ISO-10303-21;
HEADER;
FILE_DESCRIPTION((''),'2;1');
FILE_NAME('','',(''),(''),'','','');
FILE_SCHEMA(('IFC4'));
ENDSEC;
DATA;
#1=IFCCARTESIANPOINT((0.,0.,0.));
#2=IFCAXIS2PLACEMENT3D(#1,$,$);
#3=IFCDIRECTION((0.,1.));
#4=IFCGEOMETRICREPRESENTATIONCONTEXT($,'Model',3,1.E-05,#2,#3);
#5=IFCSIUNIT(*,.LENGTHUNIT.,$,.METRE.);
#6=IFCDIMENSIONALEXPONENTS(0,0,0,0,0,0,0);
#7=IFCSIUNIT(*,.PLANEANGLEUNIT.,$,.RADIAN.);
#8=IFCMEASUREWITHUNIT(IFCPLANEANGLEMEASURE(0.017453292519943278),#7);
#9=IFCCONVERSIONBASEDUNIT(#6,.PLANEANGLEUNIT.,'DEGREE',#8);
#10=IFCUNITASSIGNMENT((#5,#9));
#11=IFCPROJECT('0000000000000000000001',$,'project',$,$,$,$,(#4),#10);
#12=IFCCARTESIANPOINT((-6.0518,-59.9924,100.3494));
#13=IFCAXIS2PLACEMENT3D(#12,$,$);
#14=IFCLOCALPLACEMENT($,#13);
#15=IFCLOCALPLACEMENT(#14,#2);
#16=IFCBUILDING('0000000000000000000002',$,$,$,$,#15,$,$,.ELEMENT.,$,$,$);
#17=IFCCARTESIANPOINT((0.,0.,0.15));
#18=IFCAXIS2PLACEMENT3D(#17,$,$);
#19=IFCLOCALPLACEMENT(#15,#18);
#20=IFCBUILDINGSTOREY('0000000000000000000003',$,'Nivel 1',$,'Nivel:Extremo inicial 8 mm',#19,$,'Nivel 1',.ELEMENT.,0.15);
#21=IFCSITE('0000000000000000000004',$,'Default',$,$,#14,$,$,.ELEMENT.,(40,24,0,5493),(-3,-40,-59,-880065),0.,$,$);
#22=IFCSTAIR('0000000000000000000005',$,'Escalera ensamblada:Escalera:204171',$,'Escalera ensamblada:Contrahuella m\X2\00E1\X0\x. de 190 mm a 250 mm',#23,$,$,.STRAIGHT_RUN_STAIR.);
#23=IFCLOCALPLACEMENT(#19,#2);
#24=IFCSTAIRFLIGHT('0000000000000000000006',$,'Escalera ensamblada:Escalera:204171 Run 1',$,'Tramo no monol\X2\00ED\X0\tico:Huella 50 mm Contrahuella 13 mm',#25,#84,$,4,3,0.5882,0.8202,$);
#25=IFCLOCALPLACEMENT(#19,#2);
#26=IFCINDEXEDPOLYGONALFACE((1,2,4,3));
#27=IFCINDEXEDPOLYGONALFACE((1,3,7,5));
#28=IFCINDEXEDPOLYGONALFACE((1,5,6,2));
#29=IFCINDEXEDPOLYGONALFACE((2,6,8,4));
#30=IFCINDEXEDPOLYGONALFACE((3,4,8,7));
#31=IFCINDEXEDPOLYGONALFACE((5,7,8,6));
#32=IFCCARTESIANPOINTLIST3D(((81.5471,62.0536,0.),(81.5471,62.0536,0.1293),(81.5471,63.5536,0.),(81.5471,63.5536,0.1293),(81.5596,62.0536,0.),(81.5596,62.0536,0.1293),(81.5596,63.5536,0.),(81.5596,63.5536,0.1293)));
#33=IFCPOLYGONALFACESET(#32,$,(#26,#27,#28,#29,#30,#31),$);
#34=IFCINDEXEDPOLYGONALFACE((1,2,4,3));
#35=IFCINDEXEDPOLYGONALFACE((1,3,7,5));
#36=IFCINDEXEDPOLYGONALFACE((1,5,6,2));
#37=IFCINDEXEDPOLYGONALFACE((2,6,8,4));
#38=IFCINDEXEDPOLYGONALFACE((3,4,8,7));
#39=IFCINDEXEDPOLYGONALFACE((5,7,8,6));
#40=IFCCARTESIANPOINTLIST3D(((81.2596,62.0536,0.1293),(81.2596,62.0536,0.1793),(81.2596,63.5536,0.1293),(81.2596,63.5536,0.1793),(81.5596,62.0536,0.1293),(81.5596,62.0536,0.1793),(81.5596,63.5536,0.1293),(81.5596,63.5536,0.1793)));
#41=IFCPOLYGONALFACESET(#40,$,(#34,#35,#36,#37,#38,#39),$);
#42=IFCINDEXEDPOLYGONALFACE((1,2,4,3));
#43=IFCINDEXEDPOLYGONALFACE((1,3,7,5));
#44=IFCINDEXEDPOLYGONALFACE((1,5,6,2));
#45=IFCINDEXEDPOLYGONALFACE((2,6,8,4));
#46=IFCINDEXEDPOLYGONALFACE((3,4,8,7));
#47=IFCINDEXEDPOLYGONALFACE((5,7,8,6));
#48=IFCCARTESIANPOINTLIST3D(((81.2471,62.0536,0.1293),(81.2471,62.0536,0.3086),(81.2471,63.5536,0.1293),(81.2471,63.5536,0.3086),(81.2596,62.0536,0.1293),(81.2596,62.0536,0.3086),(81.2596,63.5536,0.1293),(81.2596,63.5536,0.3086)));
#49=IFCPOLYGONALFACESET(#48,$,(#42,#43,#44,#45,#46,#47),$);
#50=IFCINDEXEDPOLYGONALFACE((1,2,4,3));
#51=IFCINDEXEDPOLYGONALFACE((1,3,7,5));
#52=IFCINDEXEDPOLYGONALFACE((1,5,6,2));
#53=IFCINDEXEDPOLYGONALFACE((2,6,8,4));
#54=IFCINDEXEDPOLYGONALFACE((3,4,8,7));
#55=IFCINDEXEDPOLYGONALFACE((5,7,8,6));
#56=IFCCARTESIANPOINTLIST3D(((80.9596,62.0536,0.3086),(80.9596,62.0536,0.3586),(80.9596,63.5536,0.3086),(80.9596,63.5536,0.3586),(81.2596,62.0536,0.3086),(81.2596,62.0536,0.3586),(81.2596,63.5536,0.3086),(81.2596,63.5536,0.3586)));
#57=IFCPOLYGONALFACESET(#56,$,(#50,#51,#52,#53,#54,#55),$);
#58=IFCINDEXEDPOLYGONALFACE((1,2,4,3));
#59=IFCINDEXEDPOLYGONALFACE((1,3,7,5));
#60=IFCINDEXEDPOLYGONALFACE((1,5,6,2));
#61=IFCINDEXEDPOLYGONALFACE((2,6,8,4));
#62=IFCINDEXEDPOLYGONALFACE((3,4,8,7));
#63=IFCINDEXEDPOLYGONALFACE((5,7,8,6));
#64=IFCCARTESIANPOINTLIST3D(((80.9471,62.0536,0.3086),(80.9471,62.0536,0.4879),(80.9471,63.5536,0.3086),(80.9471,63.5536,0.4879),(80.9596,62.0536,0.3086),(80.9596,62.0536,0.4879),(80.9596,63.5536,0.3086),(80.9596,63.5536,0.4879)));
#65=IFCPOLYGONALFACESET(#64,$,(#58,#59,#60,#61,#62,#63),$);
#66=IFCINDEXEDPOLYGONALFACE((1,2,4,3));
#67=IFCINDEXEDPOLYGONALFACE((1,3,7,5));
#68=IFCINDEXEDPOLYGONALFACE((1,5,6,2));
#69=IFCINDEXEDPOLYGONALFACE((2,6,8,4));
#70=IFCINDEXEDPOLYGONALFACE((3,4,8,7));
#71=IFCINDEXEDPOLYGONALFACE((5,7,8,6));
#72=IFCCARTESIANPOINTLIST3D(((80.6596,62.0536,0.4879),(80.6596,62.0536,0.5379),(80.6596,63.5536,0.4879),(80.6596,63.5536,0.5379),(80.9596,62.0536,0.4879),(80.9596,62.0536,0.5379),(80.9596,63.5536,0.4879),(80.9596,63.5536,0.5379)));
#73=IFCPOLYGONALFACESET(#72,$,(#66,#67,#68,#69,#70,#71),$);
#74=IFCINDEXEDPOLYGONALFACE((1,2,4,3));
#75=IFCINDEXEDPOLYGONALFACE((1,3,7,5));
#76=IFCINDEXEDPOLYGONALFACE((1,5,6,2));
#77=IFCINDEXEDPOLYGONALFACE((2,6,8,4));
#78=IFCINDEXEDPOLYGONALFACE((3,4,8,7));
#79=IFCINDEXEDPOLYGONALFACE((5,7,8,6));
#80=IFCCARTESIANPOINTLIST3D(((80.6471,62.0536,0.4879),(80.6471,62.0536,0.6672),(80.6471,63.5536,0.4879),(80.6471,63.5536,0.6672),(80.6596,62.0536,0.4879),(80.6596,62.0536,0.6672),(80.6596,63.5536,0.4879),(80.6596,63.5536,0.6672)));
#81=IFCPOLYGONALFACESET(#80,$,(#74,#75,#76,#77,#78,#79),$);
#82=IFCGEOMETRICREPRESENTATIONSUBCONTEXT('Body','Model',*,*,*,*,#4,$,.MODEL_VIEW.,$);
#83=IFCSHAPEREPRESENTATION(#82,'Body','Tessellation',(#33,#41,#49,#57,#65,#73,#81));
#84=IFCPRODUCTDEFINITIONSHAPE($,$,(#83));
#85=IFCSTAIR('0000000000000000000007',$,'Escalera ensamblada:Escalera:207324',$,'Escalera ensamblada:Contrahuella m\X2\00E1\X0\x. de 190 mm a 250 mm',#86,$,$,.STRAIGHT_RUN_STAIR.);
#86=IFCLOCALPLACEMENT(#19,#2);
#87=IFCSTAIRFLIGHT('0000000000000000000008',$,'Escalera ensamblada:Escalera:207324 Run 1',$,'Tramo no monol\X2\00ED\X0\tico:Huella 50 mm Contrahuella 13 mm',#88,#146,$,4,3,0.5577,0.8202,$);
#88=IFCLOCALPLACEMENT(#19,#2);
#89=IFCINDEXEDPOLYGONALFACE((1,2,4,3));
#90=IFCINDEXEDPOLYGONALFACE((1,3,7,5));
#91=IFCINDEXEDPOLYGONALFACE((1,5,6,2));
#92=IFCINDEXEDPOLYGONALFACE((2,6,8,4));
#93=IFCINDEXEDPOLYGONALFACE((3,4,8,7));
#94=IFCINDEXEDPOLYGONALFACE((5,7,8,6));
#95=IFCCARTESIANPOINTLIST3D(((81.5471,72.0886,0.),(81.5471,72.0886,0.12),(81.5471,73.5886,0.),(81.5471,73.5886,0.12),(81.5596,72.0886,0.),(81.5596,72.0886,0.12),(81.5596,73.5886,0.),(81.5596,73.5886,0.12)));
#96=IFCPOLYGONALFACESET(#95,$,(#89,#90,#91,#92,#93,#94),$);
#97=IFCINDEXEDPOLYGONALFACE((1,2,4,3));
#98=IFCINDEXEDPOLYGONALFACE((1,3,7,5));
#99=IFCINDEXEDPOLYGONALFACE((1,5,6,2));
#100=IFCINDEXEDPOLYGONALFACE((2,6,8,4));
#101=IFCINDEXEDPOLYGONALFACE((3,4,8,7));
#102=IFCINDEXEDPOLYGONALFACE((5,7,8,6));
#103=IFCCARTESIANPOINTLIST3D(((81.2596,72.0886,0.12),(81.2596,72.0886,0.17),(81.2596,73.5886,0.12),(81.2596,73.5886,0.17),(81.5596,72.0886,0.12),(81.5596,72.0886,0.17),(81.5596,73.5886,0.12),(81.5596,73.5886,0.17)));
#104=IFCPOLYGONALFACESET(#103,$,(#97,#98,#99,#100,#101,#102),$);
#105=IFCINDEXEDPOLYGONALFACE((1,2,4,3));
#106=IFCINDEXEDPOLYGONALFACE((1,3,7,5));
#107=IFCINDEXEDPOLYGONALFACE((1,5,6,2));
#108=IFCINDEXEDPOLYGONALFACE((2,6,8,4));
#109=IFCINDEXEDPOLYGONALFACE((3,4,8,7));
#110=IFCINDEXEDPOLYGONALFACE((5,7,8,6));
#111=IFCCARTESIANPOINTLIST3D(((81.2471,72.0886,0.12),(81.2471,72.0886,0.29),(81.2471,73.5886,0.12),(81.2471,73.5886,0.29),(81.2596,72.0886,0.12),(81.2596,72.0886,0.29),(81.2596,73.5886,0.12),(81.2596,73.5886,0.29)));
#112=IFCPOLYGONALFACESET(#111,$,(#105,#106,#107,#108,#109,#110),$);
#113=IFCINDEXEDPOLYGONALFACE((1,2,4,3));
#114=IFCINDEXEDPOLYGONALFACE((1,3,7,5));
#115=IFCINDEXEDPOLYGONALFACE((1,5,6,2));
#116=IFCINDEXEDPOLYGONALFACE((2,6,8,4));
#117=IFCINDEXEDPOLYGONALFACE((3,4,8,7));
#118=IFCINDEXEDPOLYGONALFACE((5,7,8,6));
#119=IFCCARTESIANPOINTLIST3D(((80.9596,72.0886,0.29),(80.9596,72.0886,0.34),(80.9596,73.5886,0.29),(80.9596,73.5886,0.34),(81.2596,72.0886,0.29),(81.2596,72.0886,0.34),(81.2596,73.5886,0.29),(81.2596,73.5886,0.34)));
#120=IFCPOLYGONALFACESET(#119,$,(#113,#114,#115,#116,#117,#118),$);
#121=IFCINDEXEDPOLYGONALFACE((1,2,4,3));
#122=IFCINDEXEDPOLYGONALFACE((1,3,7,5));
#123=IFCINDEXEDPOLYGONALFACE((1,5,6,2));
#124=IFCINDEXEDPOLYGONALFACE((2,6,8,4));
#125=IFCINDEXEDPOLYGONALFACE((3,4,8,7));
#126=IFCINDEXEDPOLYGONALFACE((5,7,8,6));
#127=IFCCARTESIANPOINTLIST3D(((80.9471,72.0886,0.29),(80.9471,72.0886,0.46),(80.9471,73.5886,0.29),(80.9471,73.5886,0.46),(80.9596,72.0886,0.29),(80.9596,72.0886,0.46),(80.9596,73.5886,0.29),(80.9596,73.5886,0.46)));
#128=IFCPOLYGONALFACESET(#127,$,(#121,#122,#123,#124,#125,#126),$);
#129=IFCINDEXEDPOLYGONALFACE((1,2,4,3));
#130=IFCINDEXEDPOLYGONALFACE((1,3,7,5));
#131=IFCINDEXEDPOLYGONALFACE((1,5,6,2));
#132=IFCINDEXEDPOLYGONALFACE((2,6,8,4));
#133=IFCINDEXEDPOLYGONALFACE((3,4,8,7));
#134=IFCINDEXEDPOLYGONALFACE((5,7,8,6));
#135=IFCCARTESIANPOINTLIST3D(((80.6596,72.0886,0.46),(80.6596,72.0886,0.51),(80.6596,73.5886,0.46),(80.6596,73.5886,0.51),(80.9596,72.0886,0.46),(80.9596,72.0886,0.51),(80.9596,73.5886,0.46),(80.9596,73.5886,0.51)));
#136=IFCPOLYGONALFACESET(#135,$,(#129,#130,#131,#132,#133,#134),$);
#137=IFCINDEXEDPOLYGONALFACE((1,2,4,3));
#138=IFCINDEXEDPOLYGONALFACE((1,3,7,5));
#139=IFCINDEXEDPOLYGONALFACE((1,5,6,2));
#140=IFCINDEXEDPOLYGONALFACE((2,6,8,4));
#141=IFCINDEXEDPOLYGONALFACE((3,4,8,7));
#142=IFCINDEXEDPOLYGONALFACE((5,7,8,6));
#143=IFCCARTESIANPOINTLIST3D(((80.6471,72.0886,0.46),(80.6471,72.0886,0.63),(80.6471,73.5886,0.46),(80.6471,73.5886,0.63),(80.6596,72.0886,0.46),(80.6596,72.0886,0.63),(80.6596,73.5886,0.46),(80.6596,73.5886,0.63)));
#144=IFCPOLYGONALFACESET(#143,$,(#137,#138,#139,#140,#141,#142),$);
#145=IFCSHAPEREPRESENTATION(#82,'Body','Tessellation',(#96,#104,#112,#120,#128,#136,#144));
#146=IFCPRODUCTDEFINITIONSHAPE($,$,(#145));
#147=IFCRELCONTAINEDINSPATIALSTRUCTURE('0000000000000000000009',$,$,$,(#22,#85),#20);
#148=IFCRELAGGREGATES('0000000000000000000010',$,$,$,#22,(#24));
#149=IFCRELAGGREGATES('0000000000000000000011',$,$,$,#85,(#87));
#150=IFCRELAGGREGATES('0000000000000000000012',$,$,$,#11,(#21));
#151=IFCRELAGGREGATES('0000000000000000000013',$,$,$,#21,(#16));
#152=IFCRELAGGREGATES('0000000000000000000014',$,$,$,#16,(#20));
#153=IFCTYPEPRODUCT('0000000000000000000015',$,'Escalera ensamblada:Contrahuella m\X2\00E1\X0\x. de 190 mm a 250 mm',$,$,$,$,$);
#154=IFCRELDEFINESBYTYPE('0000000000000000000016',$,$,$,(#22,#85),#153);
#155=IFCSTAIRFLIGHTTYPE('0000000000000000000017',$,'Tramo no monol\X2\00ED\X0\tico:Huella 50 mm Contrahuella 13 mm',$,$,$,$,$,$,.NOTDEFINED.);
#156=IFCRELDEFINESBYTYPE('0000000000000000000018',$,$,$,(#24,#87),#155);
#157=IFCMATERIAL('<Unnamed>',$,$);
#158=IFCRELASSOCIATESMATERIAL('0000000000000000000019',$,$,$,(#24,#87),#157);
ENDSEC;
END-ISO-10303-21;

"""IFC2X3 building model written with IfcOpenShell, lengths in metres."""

from ifc_helpers import new_model, entity, si_unit, converted_unit, direction, frame, frame_2d, origin, origin_2d_with_axis, place, context, subcontext, project, spatial, rectangle, extrude, material, type_object, element, aggregate, save


model = new_model("IFC2X3")

# Units and contexts
model_context = context("Model", 3, precision=1e-05, world=origin(), true_north=direction((0.0, 1.0)))
body_context = subcontext(model_context, "Body", "Model", "MODEL_VIEW")
ifc_project = project(units=[si_unit("LENGTHUNIT", "METRE"), converted_unit("PLANEANGLEUNIT", "DEGREE", entity("IfcPlaneAngleMeasure", 0.017453292519943278), si_unit("PLANEANGLEUNIT", "RADIAN"), dimensions=[0, 0, 0, 0, 0, 0, 0])], contexts=[model_context])

# Site, building, storey
site_placement = place(None, frame((-6.0518, -59.9924, 100.3494)))
site = spatial("IfcSite", under=ifc_project, at=site_placement, Name="Default", CompositionType="ELEMENT", RefLatitude=(40, 24, 0, 5493), RefLongitude=(-3, -40, -59, -880065), RefElevation=0.0)
building_placement = place(site_placement, origin())
building = spatial("IfcBuilding", under=site, at=building_placement, CompositionType="ELEMENT")
storey_placement = place(building_placement, frame((0.0, 0.0, 0.15)))
storey = spatial("IfcBuildingStorey", under=building, at=storey_placement, Name="Nivel 1", ObjectType="Nivel:Extremo inicial 8 mm", LongName="Nivel 1", CompositionType="ELEMENT", Elevation=0.15)

# Stairs, stair flights
type_product = type_object("IfcTypeProduct", Name="Escalera ensamblada:Contrahuella máx. de 190 mm a 250 mm")
stair_1_placement = place(storey_placement, origin())
stair_1 = element("IfcStair", 1, at=stair_1_placement, inside=storey, type_object=type_product, Name="Escalera ensamblada:Escalera:204171", ObjectType="Escalera ensamblada:Contrahuella máx. de 190 mm a 250 mm", ShapeType="STRAIGHT_RUN_STAIR")
ifc_material_1 = material(Name="<Unnamed>")
stair_flight_type = type_object("IfcStairFlightType", Name="Tramo no monolítico:Huella 50 mm Contrahuella 13 mm", PredefinedType="NOTDEFINED")
stair_flight_1_placement = place(stair_1_placement, origin())
stair_flight_1 = element("IfcStairFlight", 2, at=stair_flight_1_placement, type_object=stair_flight_type, material=ifc_material_1, Name="Escalera ensamblada:Escalera:204171 Run 1", ObjectType="Tramo no monolítico:Huella 50 mm Contrahuella 13 mm", NumberOfRiser=4, NumberOfTreads=3, RiserHeight=0.5882, TreadLength=0.8202, context=body_context, shape_type="SweptSolid", body=[
    extrude(rectangle(XDim=1.5, YDim=0.0125, at=origin_2d_with_axis()), frame((81.5534, 62.8036, 0.0), z_axis=(0.0, 0.0, 1.0), x_axis=(0.0, -1.0, 0.0)), (0.0, 0.0, 1.0), 0.1293),
    extrude(rectangle(XDim=0.3, YDim=1.5, at=frame_2d((0.0, 0.0), x_axis=(1.0, 0.0))), frame((81.4096, 62.8036, 0.1293)), (0.0, 0.0, 1.0), 0.05),
    extrude(rectangle(XDim=1.5, YDim=0.0125, at=origin_2d_with_axis()), frame((81.2534, 62.8036, 0.1293), z_axis=(0.0, 0.0, 1.0), x_axis=(0.0, -1.0, 0.0)), (0.0, 0.0, 1.0), 0.1793),
    extrude(rectangle(XDim=0.3, YDim=1.5, at=frame_2d((0.0, 0.0), x_axis=(1.0, 0.0))), frame((81.1096, 62.8036, 0.3086)), (0.0, 0.0, 1.0), 0.05),
    extrude(rectangle(XDim=1.5, YDim=0.0125, at=origin_2d_with_axis()), frame((80.9534, 62.8036, 0.3086), z_axis=(0.0, 0.0, 1.0), x_axis=(0.0, -1.0, 0.0)), (0.0, 0.0, 1.0), 0.1793),
    extrude(rectangle(XDim=0.3, YDim=1.5, at=frame_2d((0.0, 0.0), x_axis=(1.0, 0.0))), frame((80.8096, 62.8036, 0.4879)), (0.0, 0.0, 1.0), 0.05),
    extrude(rectangle(XDim=1.5, YDim=0.0125, at=origin_2d_with_axis()), frame((80.6534, 62.8036, 0.4879), z_axis=(0.0, 0.0, 1.0), x_axis=(0.0, -1.0, 0.0)), (0.0, 0.0, 1.0), 0.1793),
])
aggregate(stair_1, [stair_flight_1])
stair_2_placement = place(storey_placement, origin())
stair_2 = element("IfcStair", 3, at=stair_2_placement, inside=storey, type_object=type_product, Name="Escalera ensamblada:Escalera:207324", ObjectType="Escalera ensamblada:Contrahuella máx. de 190 mm a 250 mm", ShapeType="STRAIGHT_RUN_STAIR")
stair_flight_2_placement = place(stair_2_placement, origin())
stair_flight_2 = element("IfcStairFlight", 4, at=stair_flight_2_placement, type_object=stair_flight_type, material=ifc_material_1, Name="Escalera ensamblada:Escalera:207324 Run 1", ObjectType="Tramo no monolítico:Huella 50 mm Contrahuella 13 mm", NumberOfRiser=4, NumberOfTreads=3, RiserHeight=0.5577, TreadLength=0.8202, context=body_context, shape_type="SweptSolid", body=[
    extrude(rectangle(XDim=1.5, YDim=0.0125, at=origin_2d_with_axis()), frame((81.5534, 72.8386, 0.0), z_axis=(0.0, 0.0, 1.0), x_axis=(0.0, -1.0, 0.0)), (0.0, 0.0, 1.0), 0.12),
    extrude(rectangle(XDim=0.3, YDim=1.5, at=frame_2d((0.0, 0.0), x_axis=(1.0, 0.0))), frame((81.4096, 72.8386, 0.12)), (0.0, 0.0, 1.0), 0.05),
    extrude(rectangle(XDim=1.5, YDim=0.0125, at=origin_2d_with_axis()), frame((81.2534, 72.8386, 0.12), z_axis=(0.0, 0.0, 1.0), x_axis=(0.0, -1.0, 0.0)), (0.0, 0.0, 1.0), 0.17),
    extrude(rectangle(XDim=0.3, YDim=1.5, at=frame_2d((0.0, 0.0), x_axis=(1.0, 0.0))), frame((81.1096, 72.8386, 0.29)), (0.0, 0.0, 1.0), 0.05),
    extrude(rectangle(XDim=1.5, YDim=0.0125, at=origin_2d_with_axis()), frame((80.9534, 72.8386, 0.29), z_axis=(0.0, 0.0, 1.0), x_axis=(0.0, -1.0, 0.0)), (0.0, 0.0, 1.0), 0.17),
    extrude(rectangle(XDim=0.3, YDim=1.5, at=frame_2d((0.0, 0.0), x_axis=(1.0, 0.0))), frame((80.8096, 72.8386, 0.46)), (0.0, 0.0, 1.0), 0.05),
    extrude(rectangle(XDim=1.5, YDim=0.0125, at=origin_2d_with_axis()), frame((80.6534, 72.8386, 0.46), z_axis=(0.0, 0.0, 1.0), x_axis=(0.0, -1.0, 0.0)), (0.0, 0.0, 1.0), 0.17),
])
aggregate(stair_2, [stair_flight_2])

save(model, "model.ifc")
